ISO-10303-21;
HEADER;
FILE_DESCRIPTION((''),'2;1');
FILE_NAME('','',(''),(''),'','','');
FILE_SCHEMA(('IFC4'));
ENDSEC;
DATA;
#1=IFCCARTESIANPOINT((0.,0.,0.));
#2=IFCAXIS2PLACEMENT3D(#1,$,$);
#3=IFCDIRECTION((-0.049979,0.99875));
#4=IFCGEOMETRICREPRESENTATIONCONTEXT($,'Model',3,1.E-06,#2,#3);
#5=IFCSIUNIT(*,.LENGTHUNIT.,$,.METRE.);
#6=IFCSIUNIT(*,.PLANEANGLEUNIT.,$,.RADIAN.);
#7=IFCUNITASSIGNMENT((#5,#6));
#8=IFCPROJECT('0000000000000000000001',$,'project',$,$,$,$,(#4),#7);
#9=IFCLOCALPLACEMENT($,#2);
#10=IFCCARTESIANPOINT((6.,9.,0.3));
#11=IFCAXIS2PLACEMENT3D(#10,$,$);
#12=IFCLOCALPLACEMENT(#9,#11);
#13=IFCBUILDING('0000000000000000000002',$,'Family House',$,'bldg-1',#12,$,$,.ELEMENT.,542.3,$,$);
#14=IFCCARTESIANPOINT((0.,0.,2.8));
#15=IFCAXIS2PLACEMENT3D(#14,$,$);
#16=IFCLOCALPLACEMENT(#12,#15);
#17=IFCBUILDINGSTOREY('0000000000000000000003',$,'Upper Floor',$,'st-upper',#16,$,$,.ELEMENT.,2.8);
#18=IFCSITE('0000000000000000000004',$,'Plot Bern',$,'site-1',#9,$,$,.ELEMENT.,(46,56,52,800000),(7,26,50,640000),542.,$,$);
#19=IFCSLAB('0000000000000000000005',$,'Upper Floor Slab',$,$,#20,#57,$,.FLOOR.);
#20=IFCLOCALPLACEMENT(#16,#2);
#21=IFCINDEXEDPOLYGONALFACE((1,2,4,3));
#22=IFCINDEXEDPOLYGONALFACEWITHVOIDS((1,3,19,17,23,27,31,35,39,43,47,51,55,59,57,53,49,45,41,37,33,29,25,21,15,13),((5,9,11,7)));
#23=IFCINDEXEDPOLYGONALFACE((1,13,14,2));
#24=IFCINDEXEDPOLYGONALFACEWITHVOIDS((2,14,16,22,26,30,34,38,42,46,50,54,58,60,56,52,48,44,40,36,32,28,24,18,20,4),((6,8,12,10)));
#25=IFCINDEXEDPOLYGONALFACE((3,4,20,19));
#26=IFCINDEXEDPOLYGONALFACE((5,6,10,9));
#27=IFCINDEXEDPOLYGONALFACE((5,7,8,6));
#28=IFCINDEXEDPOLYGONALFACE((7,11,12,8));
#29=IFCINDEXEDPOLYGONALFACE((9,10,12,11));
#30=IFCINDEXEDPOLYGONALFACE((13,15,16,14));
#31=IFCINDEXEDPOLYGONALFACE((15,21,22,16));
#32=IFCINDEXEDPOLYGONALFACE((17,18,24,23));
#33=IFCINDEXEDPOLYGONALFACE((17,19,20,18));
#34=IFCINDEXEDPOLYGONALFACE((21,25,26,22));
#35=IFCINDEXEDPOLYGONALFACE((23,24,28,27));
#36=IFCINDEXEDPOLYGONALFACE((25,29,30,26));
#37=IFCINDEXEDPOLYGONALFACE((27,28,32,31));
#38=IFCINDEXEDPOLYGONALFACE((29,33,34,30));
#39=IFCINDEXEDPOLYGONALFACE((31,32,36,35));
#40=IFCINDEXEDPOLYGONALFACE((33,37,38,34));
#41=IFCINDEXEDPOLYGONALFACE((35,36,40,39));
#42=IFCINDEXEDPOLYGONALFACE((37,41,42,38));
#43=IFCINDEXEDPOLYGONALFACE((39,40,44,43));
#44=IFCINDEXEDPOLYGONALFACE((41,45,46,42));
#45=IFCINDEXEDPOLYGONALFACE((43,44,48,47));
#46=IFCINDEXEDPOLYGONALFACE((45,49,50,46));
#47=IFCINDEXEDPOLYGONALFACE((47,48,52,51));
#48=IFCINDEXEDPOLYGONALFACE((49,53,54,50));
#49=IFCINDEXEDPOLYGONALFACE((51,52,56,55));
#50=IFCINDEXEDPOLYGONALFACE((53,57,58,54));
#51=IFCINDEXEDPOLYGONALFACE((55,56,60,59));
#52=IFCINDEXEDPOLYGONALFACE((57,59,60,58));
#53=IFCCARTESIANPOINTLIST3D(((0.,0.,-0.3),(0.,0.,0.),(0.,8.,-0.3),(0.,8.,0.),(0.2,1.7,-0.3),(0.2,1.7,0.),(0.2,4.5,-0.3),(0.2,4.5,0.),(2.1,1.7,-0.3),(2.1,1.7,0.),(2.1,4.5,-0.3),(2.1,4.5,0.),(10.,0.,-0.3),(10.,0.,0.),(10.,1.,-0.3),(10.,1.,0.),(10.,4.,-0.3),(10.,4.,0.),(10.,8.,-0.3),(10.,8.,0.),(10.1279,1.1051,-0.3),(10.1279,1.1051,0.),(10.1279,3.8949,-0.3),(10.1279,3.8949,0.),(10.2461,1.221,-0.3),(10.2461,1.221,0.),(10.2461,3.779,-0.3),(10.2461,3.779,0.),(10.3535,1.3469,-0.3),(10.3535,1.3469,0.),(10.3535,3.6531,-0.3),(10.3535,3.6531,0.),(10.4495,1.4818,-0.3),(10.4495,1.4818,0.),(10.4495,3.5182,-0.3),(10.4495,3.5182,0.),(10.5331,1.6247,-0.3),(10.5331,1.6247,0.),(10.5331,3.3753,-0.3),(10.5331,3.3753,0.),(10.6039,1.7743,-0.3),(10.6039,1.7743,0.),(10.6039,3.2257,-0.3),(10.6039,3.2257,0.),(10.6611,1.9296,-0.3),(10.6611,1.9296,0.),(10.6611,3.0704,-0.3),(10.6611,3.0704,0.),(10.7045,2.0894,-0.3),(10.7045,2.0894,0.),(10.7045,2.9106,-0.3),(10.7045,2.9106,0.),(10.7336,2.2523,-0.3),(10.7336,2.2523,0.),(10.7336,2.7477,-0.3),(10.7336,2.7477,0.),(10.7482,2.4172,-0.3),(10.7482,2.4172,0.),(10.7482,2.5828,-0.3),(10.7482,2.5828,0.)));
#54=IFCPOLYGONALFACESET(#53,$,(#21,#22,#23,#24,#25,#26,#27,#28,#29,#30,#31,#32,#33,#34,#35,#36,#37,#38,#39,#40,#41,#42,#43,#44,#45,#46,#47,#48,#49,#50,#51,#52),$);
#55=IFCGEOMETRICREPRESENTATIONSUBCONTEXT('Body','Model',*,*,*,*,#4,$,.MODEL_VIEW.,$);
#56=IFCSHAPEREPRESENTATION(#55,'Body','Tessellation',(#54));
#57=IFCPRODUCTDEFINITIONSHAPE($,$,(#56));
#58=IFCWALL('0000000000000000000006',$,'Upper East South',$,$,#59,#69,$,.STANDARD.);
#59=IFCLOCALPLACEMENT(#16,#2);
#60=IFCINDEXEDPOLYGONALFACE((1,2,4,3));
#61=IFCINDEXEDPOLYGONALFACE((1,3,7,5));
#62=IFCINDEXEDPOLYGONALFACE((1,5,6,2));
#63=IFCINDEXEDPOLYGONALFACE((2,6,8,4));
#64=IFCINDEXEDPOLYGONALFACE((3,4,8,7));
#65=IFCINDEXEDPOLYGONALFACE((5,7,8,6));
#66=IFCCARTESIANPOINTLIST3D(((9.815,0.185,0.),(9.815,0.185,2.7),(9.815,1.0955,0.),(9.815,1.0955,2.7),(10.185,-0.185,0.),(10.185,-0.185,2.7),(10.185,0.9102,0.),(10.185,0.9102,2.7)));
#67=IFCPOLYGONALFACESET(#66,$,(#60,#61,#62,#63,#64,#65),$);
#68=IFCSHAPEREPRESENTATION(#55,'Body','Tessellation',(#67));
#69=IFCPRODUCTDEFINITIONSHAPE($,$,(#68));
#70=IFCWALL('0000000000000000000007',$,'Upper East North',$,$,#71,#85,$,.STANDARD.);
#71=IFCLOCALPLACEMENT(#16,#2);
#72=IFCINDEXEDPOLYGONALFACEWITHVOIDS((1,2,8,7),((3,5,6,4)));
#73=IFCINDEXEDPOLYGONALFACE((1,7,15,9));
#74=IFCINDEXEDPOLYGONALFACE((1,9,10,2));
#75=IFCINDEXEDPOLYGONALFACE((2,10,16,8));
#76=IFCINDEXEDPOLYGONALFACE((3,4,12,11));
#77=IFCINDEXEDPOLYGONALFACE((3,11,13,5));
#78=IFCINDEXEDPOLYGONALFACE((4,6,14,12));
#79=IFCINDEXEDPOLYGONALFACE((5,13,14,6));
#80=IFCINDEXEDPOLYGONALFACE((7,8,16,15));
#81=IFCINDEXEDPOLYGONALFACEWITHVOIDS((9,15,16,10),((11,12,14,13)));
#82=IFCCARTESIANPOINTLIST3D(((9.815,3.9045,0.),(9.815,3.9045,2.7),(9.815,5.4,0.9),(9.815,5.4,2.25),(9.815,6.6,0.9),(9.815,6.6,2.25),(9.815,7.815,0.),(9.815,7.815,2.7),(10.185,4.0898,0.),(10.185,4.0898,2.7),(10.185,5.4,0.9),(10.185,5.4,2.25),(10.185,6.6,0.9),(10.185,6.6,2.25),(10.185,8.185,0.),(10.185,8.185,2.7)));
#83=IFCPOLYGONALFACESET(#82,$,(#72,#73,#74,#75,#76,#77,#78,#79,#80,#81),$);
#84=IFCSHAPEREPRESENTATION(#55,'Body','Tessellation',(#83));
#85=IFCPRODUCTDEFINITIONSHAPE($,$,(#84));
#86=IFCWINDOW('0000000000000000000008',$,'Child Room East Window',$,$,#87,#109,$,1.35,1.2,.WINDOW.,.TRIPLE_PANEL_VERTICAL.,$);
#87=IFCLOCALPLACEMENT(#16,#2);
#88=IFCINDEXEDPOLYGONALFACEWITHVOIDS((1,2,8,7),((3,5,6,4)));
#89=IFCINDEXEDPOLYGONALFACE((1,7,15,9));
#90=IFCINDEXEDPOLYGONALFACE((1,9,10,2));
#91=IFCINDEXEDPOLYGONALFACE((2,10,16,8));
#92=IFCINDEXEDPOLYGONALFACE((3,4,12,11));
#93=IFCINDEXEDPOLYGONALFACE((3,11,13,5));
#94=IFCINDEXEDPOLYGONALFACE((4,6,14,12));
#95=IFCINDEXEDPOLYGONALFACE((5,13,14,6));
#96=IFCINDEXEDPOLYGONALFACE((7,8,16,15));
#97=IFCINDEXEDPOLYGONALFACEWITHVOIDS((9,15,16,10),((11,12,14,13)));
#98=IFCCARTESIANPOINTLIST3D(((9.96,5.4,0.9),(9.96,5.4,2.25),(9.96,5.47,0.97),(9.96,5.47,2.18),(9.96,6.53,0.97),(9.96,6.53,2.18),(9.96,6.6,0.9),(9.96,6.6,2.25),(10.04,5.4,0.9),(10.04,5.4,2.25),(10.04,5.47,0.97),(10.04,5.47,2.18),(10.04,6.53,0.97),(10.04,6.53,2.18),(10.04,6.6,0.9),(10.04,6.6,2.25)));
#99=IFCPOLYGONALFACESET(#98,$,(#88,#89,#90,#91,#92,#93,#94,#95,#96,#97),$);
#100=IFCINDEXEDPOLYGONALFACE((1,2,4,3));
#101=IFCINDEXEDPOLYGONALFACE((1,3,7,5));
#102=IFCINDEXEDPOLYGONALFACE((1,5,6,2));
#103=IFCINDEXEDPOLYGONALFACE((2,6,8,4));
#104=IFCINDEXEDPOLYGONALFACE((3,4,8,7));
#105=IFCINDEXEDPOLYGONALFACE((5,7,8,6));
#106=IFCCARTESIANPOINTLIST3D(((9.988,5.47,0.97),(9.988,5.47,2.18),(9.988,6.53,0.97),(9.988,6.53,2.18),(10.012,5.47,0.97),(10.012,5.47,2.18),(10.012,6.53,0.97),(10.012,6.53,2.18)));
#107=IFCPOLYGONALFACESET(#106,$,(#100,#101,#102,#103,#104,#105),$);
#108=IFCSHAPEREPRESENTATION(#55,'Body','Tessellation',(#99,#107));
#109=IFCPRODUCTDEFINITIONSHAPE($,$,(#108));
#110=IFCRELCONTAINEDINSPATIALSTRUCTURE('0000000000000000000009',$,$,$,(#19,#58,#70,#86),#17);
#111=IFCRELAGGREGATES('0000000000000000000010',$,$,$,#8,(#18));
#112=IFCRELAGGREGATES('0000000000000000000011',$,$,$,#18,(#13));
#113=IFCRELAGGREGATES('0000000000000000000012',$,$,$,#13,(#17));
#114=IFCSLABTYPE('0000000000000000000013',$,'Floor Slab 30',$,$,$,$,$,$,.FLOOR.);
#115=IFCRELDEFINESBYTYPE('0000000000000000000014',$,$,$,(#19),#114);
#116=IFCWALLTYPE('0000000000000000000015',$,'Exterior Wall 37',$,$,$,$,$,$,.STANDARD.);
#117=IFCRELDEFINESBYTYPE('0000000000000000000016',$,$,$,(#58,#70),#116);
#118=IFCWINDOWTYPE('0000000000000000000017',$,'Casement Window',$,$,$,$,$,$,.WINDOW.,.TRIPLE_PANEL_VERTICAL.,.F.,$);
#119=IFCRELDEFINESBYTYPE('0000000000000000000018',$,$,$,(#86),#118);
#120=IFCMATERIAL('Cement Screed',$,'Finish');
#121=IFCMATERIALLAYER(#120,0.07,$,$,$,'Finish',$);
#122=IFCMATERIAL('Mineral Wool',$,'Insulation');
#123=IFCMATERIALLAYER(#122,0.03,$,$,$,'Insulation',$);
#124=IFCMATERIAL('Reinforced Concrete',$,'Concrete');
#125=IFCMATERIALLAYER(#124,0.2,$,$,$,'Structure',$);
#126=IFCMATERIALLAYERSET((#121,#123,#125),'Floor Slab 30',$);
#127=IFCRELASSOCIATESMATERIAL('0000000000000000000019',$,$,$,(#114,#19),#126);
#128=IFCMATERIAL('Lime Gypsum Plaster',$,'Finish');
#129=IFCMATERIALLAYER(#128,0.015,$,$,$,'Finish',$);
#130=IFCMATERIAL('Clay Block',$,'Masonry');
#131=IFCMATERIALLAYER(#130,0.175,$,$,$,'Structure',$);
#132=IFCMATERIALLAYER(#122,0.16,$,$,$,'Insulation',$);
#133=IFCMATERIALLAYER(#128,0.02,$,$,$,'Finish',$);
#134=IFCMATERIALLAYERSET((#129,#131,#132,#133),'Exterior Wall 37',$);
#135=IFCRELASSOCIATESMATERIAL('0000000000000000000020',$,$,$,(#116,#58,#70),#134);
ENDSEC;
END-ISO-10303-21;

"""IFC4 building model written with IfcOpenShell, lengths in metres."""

from ifc_helpers import new_model, si_unit, point, direction, frame, frame_2d, origin, origin_2d, place, context, subcontext, project, spatial, polyline, circle_curve, trimmed, segment, composite_curve, rectangle, outline, extrude, material, layer, layer_set, layer_usage, type_object, element, fill, save


model = new_model("IFC4")

# Units and contexts
model_context = context("Model", 3, precision=1e-06, world=origin(), true_north=direction((-0.049979, 0.99875)))
body_context = subcontext(model_context, "Body", "Model", "MODEL_VIEW")
ifc_project = project(units=[si_unit("LENGTHUNIT", "METRE"), si_unit("PLANEANGLEUNIT", "RADIAN")], contexts=[model_context])

# Site, building, storey
site_placement = place(None, origin())
site = spatial("IfcSite", under=ifc_project, at=site_placement, Name="Plot Bern", ObjectType="site-1", CompositionType="ELEMENT", RefLatitude=(46, 56, 52, 800000), RefLongitude=(7, 26, 50, 640000), RefElevation=542.0)
building_placement = place(site_placement, frame((6.0, 9.0, 0.3)))
building = spatial("IfcBuilding", under=site, at=building_placement, Name="Family House", ObjectType="bldg-1", CompositionType="ELEMENT", ElevationOfRefHeight=542.3)
storey_placement = place(building_placement, frame((0.0, 0.0, 2.8)))
storey = spatial("IfcBuildingStorey", under=building, at=storey_placement, Name="Upper Floor", ObjectType="st-upper", CompositionType="ELEMENT", Elevation=2.8)

# Slab
ifc_material_1 = material(Name="Cement Screed", Category="Finish")
ifc_layer_1 = layer(ifc_material_1, 0.07, Category="Finish")
ifc_material_2 = material(Name="Mineral Wool", Category="Insulation")
ifc_layer_2 = layer(ifc_material_2, 0.03, Category="Insulation")
ifc_material_3 = material(Name="Reinforced Concrete", Category="Concrete")
ifc_layer_3 = layer(ifc_material_3, 0.2, Category="Structure")
ifc_layer_set_1 = layer_set([ifc_layer_1, ifc_layer_2, ifc_layer_3], Name="Floor Slab 30")
ifc_layer_usage_1 = layer_usage(ifc_layer_set_1, "AXIS3", "NEGATIVE", 0.3)
slab_type = type_object("IfcSlabType", Name="Floor Slab 30", PredefinedType="FLOOR", material=ifc_layer_set_1)
slab_placement = place(storey_placement, frame((0.0, 0.0, -0.3)))
element("IfcSlab", 1, at=slab_placement, inside=storey, type_object=slab_type, material=ifc_layer_usage_1, Name="Upper Floor Slab", PredefinedType="FLOOR", context=body_context, shape_type="SweptSolid", body=[
    extrude(outline(composite_curve([segment(polyline([(0.0, 0.0), (10.0, 0.0)]), True, "CONTINUOUS"), segment(polyline([(10.0, 0.0), (10.0, 1.0)]), True, "CONTINUOUS"), segment(trimmed(circle_curve(frame_2d((8.875, 2.5)), 1.875), [point((10.0, 1.0))], [point((10.0, 4.0))], True, "CARTESIAN"), True, "CONTINUOUS"), segment(polyline([(10.0, 4.0), (10.0, 8.0)]), True, "CONTINUOUS"), segment(polyline([(10.0, 8.0), (0.0, 8.0)]), True, "CONTINUOUS"), segment(polyline([(0.0, 8.0), (0.0, 0.0)]), True, "CONTINUOUS")], self_intersect=False), holes=[polyline([(0.2, 1.7), (0.2, 4.5), (2.1, 4.5), (2.1, 1.7), (0.2, 1.7)])]), origin(), (0.0, 0.0, 1.0), 0.3),
])

# Shared definitions
ifc_material_4 = material(Name="Lime Gypsum Plaster", Category="Finish")
ifc_layer_4 = layer(ifc_material_4, 0.015, Category="Finish")
ifc_material_5 = material(Name="Clay Block", Category="Masonry")
ifc_layer_5 = layer(ifc_material_5, 0.175, Category="Structure")
ifc_layer_6 = layer(ifc_material_2, 0.16, Category="Insulation")
ifc_layer_7 = layer(ifc_material_4, 0.02, Category="Finish")
ifc_layer_set_2 = layer_set([ifc_layer_4, ifc_layer_5, ifc_layer_6, ifc_layer_7], Name="Exterior Wall 37")
wall_type_1 = type_object("IfcWallType", Name="Exterior Wall 37", PredefinedType="STANDARD", material=ifc_layer_set_2)

# Wall
ifc_layer_usage_2 = layer_usage(ifc_layer_set_2, "AXIS2", "NEGATIVE", 0.185)
wall_1_placement = place(storey_placement, origin())
element("IfcWall", 2, at=wall_1_placement, inside=storey, type_object=wall_type_1, material=ifc_layer_usage_2, Name="Upper East South", PredefinedType="STANDARD", context=body_context, shape_type="SweptSolid", body=[
    extrude(outline(polyline([(10.185, -0.185), (10.185, 0.9102), (9.815, 1.0955), (9.815, 0.185), (10.185, -0.185)])), origin(), (0.0, 0.0, 1.0), 2.7),
])

# Wall, opening, window
ifc_layer_usage_3 = layer_usage(ifc_layer_set_2, "AXIS2", "NEGATIVE", 0.185)
wall_2_placement = place(storey_placement, origin())
wall_2 = element("IfcWall", 3, at=wall_2_placement, inside=storey, type_object=wall_type_1, material=ifc_layer_usage_3, Name="Upper East North", PredefinedType="STANDARD", context=body_context, shape_type="SweptSolid", body=[
    extrude(outline(polyline([(10.185, 4.0898), (10.185, 8.185), (9.815, 7.815), (9.815, 3.9045), (10.185, 4.0898)])), origin(), (0.0, 0.0, 1.0), 2.7),
])
opening_1_placement = place(wall_2_placement, frame((10.0, 6.0, 0.9), z_axis=(0.0, 0.0, 1.0), x_axis=(0.0, 1.0, 0.0)))
opening_1 = element("IfcOpeningElement", 4, at=opening_1_placement, cuts=wall_2, PredefinedType="OPENING", context=body_context, shape_type="SweptSolid", body=[
    extrude(rectangle(XDim=1.2, YDim=0.37, at=origin_2d()), origin(), (0.0, 0.0, 1.0), 1.35),
])
window_type_1 = type_object("IfcWindowType", Name="Casement Window", ParameterTakesPrecedence=False, PartitioningType="TRIPLE_PANEL_VERTICAL", PredefinedType="WINDOW")
window_1_placement = place(opening_1_placement, frame((0.0, 0.0, 0.0), z_axis=(0.0, -1.0, 0.0), x_axis=(1.0, 0.0, 0.0)))
window_1 = element("IfcWindow", 5, at=window_1_placement, inside=storey, type_object=window_type_1, Name="Child Room East Window", OverallHeight=1.35, OverallWidth=1.2, PartitioningType="TRIPLE_PANEL_VERTICAL", PredefinedType="WINDOW", context=body_context, shape_type="SweptSolid", body=[
    extrude(outline(polyline([(-0.6, 0.0), (0.6, 0.0), (0.6, 1.35), (-0.6, 1.35), (-0.6, 0.0)]), holes=[polyline([(-0.53, 0.07), (0.53, 0.07), (0.53, 1.28), (-0.53, 1.28), (-0.53, 0.07)])]), frame((0.0, 0.0, -0.04)), (0.0, 0.0, 1.0), 0.08),
    extrude(rectangle(XDim=1.06, YDim=1.21, at=frame_2d((0.0, 0.675))), frame((0.0, 0.0, -0.012)), (0.0, 0.0, 1.0), 0.024),
])
fill(opening_1, window_1)

save(model, "model.ifc")
